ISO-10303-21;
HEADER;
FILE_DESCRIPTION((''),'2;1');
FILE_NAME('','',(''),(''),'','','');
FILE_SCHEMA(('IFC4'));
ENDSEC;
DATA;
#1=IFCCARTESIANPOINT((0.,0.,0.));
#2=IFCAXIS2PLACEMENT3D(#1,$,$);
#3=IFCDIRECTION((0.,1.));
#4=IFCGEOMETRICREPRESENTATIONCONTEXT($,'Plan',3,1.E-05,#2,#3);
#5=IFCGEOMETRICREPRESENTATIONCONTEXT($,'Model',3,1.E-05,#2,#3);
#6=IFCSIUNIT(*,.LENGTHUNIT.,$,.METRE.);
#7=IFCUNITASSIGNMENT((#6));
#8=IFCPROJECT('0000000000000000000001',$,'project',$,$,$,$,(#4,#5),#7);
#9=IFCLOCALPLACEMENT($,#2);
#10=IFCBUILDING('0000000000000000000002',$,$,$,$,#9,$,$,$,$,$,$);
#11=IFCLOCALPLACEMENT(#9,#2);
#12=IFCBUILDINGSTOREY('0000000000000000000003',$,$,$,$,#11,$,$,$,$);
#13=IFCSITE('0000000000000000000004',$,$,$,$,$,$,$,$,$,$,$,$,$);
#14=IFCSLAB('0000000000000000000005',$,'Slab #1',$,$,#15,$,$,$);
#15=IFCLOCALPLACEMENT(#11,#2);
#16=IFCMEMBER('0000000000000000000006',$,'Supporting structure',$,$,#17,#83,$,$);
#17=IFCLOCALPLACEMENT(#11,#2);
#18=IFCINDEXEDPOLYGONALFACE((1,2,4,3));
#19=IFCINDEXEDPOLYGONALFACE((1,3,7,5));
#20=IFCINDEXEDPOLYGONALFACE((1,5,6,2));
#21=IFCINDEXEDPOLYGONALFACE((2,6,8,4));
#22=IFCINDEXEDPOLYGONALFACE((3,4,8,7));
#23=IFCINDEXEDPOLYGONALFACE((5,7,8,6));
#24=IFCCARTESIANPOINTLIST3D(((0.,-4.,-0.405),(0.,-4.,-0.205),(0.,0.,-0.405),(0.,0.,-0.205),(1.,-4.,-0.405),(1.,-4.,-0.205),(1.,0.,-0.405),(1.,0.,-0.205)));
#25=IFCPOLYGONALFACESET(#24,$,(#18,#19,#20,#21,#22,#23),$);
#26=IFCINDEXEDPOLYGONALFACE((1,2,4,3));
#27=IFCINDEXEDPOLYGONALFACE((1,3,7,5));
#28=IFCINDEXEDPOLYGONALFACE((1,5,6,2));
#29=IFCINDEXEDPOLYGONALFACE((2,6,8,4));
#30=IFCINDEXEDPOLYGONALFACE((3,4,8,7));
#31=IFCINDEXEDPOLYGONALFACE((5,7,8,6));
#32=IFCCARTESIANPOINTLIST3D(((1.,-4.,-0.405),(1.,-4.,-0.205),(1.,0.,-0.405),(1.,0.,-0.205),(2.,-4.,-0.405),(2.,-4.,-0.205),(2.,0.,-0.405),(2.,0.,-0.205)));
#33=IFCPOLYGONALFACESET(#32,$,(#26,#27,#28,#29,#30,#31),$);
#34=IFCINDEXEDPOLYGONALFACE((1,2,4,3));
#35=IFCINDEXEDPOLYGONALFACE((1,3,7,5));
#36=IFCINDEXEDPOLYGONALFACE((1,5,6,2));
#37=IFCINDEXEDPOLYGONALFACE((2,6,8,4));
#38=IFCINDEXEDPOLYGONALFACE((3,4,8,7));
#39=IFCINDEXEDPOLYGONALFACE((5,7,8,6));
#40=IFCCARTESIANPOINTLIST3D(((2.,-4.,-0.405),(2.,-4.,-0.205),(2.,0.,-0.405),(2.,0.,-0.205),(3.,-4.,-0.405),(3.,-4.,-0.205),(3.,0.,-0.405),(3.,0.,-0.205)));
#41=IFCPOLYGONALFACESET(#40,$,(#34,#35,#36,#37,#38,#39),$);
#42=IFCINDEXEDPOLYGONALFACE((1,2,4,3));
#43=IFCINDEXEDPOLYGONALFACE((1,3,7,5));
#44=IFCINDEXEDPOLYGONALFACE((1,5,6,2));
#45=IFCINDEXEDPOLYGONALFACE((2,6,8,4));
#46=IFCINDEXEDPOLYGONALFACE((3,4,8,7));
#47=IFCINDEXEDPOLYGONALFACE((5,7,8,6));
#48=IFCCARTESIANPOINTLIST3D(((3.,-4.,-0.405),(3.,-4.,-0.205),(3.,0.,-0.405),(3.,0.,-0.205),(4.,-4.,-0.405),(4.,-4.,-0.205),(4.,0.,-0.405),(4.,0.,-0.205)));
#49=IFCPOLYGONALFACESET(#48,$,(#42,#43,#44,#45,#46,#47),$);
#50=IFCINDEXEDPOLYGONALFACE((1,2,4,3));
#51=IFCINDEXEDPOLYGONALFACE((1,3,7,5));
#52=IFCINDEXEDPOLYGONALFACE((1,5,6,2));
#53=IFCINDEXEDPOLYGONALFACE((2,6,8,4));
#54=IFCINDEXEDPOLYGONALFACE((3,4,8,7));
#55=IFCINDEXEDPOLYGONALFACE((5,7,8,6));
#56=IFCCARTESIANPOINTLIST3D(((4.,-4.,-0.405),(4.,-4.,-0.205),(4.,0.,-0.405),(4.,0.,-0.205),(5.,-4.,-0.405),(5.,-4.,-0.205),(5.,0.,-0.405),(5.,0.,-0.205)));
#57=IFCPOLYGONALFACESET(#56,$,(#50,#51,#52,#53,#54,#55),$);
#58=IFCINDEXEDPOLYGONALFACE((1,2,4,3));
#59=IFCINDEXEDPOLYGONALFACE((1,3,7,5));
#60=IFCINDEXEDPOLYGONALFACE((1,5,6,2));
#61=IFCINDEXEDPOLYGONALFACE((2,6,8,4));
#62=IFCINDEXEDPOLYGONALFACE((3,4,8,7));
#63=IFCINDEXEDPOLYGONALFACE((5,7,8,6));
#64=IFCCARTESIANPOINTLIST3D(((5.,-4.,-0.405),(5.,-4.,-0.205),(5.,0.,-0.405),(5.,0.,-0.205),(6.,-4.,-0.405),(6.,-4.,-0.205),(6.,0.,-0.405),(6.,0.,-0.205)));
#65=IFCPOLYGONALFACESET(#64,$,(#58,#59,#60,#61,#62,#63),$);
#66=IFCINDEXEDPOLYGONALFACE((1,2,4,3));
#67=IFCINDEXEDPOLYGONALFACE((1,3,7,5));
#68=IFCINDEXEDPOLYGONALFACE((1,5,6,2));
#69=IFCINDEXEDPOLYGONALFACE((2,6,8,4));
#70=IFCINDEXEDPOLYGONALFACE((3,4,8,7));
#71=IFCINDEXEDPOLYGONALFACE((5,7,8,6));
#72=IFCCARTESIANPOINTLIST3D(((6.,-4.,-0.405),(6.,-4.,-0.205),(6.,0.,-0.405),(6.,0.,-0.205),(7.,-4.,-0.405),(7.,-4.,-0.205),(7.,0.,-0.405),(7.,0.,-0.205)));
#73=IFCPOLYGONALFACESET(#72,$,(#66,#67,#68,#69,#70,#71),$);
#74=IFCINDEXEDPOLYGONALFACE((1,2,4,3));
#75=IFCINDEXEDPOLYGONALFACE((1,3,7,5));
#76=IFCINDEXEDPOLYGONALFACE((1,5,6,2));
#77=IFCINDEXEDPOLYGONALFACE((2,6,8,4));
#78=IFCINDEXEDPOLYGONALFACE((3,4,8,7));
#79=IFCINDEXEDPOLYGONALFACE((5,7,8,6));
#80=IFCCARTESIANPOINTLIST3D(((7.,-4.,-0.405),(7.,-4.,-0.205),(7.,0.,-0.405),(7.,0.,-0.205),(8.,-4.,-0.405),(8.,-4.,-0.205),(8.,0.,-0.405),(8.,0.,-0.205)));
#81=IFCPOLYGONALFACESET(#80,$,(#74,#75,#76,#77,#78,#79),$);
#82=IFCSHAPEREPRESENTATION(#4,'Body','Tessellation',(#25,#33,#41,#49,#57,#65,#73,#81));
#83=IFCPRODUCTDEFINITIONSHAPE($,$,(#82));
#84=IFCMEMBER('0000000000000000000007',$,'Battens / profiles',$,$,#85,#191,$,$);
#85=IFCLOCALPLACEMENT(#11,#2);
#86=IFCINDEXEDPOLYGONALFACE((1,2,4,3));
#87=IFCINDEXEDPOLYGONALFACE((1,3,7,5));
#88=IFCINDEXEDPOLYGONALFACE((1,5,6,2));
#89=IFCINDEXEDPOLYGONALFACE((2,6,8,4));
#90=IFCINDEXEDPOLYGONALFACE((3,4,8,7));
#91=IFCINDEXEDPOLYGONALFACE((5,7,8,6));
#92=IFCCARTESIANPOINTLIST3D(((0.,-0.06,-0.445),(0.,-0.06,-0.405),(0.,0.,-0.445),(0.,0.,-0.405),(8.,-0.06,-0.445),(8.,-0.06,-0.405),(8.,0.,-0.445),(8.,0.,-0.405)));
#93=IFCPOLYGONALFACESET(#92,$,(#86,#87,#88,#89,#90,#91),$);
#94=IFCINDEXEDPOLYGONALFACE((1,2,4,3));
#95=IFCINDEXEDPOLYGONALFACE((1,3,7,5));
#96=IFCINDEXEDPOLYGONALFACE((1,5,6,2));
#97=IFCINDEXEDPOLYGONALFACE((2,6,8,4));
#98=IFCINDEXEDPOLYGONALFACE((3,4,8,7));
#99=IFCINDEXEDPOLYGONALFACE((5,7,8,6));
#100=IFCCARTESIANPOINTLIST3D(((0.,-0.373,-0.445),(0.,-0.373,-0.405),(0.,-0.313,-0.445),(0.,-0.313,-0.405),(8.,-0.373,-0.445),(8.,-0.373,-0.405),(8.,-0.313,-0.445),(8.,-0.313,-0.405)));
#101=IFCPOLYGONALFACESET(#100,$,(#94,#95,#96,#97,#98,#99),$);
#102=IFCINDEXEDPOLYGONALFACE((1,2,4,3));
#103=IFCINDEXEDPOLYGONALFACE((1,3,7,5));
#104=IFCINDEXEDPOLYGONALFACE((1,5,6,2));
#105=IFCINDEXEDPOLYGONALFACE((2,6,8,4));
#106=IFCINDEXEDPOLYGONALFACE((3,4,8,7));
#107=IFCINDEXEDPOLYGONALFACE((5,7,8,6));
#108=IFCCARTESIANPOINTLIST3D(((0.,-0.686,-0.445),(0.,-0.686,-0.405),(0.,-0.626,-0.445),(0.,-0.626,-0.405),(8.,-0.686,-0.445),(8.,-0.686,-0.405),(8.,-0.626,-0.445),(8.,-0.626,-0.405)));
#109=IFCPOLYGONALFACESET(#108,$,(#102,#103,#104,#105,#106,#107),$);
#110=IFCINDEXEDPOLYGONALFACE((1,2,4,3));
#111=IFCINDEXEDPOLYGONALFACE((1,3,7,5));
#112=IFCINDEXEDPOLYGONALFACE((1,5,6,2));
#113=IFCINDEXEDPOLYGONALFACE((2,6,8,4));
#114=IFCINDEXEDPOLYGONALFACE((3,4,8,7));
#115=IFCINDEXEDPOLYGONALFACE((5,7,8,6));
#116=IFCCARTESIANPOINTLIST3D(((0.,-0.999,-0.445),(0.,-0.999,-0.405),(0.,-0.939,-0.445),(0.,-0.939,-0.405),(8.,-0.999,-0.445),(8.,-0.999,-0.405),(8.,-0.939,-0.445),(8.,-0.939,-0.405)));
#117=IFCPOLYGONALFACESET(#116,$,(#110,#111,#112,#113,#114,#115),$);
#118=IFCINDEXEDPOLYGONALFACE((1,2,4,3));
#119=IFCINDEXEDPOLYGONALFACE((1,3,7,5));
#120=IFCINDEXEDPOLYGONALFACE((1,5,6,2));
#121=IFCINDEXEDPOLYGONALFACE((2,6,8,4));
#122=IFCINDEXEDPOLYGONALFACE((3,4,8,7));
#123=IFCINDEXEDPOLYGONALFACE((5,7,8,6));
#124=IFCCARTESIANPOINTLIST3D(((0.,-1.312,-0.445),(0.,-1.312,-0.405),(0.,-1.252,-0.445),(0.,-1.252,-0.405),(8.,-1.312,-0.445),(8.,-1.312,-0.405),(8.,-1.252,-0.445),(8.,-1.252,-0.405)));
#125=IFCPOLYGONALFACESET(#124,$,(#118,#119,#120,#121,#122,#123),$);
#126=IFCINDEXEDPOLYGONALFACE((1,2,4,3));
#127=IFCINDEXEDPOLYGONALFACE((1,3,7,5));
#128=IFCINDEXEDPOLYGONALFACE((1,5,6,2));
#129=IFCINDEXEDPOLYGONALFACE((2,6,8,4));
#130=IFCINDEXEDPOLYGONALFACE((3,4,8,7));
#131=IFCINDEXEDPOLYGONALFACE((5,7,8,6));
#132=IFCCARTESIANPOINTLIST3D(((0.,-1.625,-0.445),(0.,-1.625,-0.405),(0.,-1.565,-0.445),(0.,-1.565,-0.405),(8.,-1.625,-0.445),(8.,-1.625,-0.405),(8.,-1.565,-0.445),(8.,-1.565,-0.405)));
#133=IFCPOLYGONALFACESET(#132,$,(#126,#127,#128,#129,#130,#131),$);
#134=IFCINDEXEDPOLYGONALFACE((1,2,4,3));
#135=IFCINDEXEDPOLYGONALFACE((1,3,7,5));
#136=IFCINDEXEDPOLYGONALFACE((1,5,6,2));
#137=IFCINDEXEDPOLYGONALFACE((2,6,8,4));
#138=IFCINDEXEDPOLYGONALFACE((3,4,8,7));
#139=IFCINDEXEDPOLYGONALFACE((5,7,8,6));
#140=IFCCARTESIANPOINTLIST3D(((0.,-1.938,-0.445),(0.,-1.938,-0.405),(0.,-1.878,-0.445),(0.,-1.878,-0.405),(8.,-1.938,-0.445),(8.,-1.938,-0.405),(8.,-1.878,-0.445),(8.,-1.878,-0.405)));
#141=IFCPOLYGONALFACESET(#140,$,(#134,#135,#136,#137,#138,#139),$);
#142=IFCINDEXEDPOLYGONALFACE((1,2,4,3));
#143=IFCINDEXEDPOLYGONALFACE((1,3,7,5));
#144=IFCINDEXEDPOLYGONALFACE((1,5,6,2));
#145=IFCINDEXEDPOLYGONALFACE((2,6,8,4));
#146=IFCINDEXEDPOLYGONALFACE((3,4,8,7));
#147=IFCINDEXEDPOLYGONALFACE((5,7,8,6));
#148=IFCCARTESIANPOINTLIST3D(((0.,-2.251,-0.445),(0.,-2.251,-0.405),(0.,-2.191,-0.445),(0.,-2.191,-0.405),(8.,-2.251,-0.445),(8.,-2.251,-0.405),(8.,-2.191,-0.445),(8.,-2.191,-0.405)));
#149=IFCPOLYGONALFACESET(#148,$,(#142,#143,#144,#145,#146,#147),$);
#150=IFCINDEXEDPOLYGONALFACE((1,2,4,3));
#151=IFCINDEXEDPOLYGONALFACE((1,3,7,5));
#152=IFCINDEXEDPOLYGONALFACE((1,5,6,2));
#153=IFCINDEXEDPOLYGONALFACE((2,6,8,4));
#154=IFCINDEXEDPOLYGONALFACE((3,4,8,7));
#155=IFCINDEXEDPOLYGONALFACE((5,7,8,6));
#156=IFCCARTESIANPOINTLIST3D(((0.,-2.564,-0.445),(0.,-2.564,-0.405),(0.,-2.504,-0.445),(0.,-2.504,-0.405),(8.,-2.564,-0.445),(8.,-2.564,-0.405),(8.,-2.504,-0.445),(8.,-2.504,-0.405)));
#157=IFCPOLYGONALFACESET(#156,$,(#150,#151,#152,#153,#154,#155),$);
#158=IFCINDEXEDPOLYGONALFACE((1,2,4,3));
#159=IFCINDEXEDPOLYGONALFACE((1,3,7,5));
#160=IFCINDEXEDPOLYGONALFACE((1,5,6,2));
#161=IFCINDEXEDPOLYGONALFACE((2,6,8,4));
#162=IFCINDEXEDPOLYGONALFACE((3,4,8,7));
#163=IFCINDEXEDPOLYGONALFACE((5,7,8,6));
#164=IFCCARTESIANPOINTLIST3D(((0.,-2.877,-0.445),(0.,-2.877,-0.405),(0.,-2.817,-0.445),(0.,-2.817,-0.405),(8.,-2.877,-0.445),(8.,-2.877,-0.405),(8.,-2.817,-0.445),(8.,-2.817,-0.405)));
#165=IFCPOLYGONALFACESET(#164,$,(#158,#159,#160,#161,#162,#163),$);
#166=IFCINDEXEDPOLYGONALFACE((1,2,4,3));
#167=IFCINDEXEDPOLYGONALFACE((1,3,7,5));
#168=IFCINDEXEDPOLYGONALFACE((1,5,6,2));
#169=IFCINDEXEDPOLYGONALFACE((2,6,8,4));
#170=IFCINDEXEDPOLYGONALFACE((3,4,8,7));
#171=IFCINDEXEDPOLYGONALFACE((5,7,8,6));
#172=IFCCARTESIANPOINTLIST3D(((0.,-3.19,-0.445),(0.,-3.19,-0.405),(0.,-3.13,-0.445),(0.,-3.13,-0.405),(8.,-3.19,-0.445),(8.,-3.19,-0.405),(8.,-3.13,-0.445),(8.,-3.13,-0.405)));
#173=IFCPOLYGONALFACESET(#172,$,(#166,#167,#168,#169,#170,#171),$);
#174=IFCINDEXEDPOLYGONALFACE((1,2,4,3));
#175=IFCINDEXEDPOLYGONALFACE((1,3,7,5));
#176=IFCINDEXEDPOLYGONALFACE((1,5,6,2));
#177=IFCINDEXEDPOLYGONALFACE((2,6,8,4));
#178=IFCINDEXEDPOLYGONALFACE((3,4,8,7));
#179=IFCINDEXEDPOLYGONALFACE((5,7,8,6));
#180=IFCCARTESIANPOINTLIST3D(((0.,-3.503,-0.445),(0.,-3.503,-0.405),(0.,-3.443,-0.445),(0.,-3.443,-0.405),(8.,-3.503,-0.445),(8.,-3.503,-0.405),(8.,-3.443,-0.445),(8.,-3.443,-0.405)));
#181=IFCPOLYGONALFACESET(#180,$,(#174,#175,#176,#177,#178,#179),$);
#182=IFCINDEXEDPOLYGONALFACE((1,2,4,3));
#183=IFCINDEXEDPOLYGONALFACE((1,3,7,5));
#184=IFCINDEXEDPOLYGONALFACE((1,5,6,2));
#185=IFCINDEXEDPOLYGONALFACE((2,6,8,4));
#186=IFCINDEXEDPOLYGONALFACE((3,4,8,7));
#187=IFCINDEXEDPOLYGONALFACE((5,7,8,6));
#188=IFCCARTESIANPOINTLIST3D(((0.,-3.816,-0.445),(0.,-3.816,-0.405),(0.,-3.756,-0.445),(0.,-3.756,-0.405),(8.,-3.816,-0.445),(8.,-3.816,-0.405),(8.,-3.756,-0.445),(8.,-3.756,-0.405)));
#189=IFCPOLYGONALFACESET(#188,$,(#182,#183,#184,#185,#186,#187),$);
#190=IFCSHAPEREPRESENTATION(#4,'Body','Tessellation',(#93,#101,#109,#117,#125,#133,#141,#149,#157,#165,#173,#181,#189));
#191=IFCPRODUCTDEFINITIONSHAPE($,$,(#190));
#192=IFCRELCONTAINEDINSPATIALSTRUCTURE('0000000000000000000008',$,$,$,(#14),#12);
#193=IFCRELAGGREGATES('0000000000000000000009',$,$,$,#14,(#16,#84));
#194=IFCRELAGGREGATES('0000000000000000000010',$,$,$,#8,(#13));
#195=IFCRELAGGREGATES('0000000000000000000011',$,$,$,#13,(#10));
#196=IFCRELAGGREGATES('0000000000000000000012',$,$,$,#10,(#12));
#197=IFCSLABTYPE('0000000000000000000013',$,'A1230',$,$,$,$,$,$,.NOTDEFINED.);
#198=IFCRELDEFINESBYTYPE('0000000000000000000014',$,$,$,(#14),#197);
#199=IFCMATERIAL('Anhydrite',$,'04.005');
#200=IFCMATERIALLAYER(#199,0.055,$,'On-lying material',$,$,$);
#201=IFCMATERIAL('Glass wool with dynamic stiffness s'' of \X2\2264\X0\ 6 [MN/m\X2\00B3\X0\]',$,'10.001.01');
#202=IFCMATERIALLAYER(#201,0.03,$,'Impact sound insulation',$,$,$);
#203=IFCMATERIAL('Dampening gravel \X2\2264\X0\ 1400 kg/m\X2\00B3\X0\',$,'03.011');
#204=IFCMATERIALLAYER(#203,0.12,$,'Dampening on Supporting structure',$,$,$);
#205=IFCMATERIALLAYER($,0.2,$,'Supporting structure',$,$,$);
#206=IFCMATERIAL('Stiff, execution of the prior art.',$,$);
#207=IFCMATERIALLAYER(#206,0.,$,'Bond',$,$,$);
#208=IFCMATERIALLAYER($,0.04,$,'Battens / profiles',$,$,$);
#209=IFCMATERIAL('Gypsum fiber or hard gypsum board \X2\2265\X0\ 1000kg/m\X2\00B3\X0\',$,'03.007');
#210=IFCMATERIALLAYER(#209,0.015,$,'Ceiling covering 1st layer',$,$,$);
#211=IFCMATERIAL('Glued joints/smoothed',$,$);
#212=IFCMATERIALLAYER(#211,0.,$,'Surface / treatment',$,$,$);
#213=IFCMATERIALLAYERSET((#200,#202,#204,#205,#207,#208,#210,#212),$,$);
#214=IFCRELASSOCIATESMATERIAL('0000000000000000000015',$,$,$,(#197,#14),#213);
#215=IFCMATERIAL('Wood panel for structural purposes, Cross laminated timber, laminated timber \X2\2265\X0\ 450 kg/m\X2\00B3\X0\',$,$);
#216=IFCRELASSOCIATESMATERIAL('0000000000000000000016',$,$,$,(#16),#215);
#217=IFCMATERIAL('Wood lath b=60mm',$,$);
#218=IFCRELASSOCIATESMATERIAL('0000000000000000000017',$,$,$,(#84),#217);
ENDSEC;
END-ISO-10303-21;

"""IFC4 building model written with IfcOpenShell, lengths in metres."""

from ifc_helpers import new_model, si_unit, direction, frame, frame_2d, origin, place, context, project, spatial, rectangle, extrude, material, layer, layer_set, type_object, element, aggregate, save


model = new_model("IFC4")

# Units and contexts
plan_context = context("Plan", 3, precision=1e-05, world=origin(), true_north=direction((0.0, 1.0)))
model_context = context("Model", 3, precision=1e-05, world=origin(), true_north=direction((0.0, 1.0)))
ifc_project = project(units=[si_unit("LENGTHUNIT", "METRE")], contexts=[plan_context, model_context])

# Site, building, storey
site = spatial("IfcSite", under=ifc_project)
building_placement = place(None, origin())
building = spatial("IfcBuilding", under=site, at=building_placement)
storey_placement = place(building_placement, origin())
storey = spatial("IfcBuildingStorey", under=building, at=storey_placement)

# Slab, members
ifc_material_1 = material(Name="Anhydrite", Category="04.005")
ifc_layer_1 = layer(ifc_material_1, 0.055, Name="On-lying material")
ifc_material_2 = material(Name="Glass wool with dynamic stiffness s' of ≤ 6 [MN/m³]", Category="10.001.01")
ifc_layer_2 = layer(ifc_material_2, 0.03, Name="Impact sound insulation")
ifc_material_3 = material(Name="Dampening gravel ≤ 1400 kg/m³", Category="03.011")
ifc_layer_3 = layer(ifc_material_3, 0.12, Name="Dampening on Supporting structure")
ifc_layer_4 = layer(None, 0.2, Name="Supporting structure")
ifc_material_4 = material(Name="Stiff, execution of the prior art.")
ifc_layer_5 = layer(ifc_material_4, 0.0, Name="Bond")
ifc_layer_6 = layer(None, 0.04, Name="Battens / profiles")
ifc_material_5 = material(Name="Gypsum fiber or hard gypsum board ≥ 1000kg/m³", Category="03.007")
ifc_layer_7 = layer(ifc_material_5, 0.015, Name="Ceiling covering 1st layer")
ifc_material_6 = material(Name="Glued joints/smoothed")
ifc_layer_8 = layer(ifc_material_6, 0.0, Name="Surface / treatment")
ifc_layer_set = layer_set([ifc_layer_1, ifc_layer_2, ifc_layer_3, ifc_layer_4, ifc_layer_5, ifc_layer_6, ifc_layer_7, ifc_layer_8])
slab_type = type_object("IfcSlabType", Name="A1230", PredefinedType="NOTDEFINED", material=ifc_layer_set)
slab_placement = place(None, frame((0.0, 0.0, 0.0), z_axis=(0.0, 0.0, -1.0), x_axis=(1.0, 0.0, 0.0)))
slab = element("IfcSlab", 1, at=slab_placement, inside=storey, type_object=slab_type, material=ifc_layer_set, Name="Slab #1")
ifc_material_7 = material(Name="Wood panel for structural purposes, Cross laminated timber, laminated timber ≥ 450 kg/m³")
member_1_placement = place(slab_placement, origin())
member_1 = element("IfcMember", 2, at=member_1_placement, material=ifc_material_7, Name="Supporting structure", context=plan_context, shape_type="SweptSolid", body=[
    extrude(rectangle(XDim=1.0, YDim=0.2, at=frame_2d((0.5, 0.1), x_axis=(1.0, 0.0))), frame((0.0, 4.0, 0.205), z_axis=(0.0, -1.0, 0.0), x_axis=(1.0, 0.0, 0.0)), (0.0, 0.0, 1.0), 4.0),
    extrude(rectangle(XDim=1.0, YDim=0.2, at=frame_2d((0.5, 0.1), x_axis=(1.0, 0.0))), frame((1.0, 4.0, 0.205), z_axis=(0.0, -1.0, 0.0), x_axis=(1.0, 0.0, 0.0)), (0.0, 0.0, 1.0), 4.0),
    extrude(rectangle(XDim=1.0, YDim=0.2, at=frame_2d((0.5, 0.1), x_axis=(1.0, 0.0))), frame((2.0, 4.0, 0.205), z_axis=(0.0, -1.0, 0.0), x_axis=(1.0, 0.0, 0.0)), (0.0, 0.0, 1.0), 4.0),
    extrude(rectangle(XDim=1.0, YDim=0.2, at=frame_2d((0.5, 0.1), x_axis=(1.0, 0.0))), frame((3.0, 4.0, 0.205), z_axis=(0.0, -1.0, 0.0), x_axis=(1.0, 0.0, 0.0)), (0.0, 0.0, 1.0), 4.0),
    extrude(rectangle(XDim=1.0, YDim=0.2, at=frame_2d((0.5, 0.1), x_axis=(1.0, 0.0))), frame((4.0, 4.0, 0.205), z_axis=(0.0, -1.0, 0.0), x_axis=(1.0, 0.0, 0.0)), (0.0, 0.0, 1.0), 4.0),
    extrude(rectangle(XDim=1.0, YDim=0.2, at=frame_2d((0.5, 0.1), x_axis=(1.0, 0.0))), frame((5.0, 4.0, 0.205), z_axis=(0.0, -1.0, 0.0), x_axis=(1.0, 0.0, 0.0)), (0.0, 0.0, 1.0), 4.0),
    extrude(rectangle(XDim=1.0, YDim=0.2, at=frame_2d((0.5, 0.1), x_axis=(1.0, 0.0))), frame((6.0, 4.0, 0.205), z_axis=(0.0, -1.0, 0.0), x_axis=(1.0, 0.0, 0.0)), (0.0, 0.0, 1.0), 4.0),
    extrude(rectangle(XDim=1.0, YDim=0.2, at=frame_2d((0.5, 0.1), x_axis=(1.0, 0.0))), frame((7.0, 4.0, 0.205), z_axis=(0.0, -1.0, 0.0), x_axis=(1.0, 0.0, 0.0)), (0.0, 0.0, 1.0), 4.0),
])
ifc_material_8 = material(Name="Wood lath b=60mm")
member_2_placement = place(slab_placement, origin())
member_2 = element("IfcMember", 3, at=member_2_placement, material=ifc_material_8, Name="Battens / profiles", context=plan_context, shape_type="SweptSolid", body=[
    extrude(rectangle(XDim=0.06, YDim=0.04, at=frame_2d((0.03, 0.02), x_axis=(1.0, 0.0))), frame((0.0, 0.0, 0.405), z_axis=(1.0, 0.0, 0.0), x_axis=(0.0, 1.0, 0.0)), (0.0, 0.0, 1.0), 8.0),
    extrude(rectangle(XDim=0.06, YDim=0.04, at=frame_2d((0.03, 0.02), x_axis=(1.0, 0.0))), frame((0.0, 0.313, 0.405), z_axis=(1.0, 0.0, 0.0), x_axis=(0.0, 1.0, 0.0)), (0.0, 0.0, 1.0), 8.0),
    extrude(rectangle(XDim=0.06, YDim=0.04, at=frame_2d((0.03, 0.02), x_axis=(1.0, 0.0))), frame((0.0, 0.626, 0.405), z_axis=(1.0, 0.0, 0.0), x_axis=(0.0, 1.0, 0.0)), (0.0, 0.0, 1.0), 8.0),
    extrude(rectangle(XDim=0.06, YDim=0.04, at=frame_2d((0.03, 0.02), x_axis=(1.0, 0.0))), frame((0.0, 0.939, 0.405), z_axis=(1.0, 0.0, 0.0), x_axis=(0.0, 1.0, 0.0)), (0.0, 0.0, 1.0), 8.0),
    extrude(rectangle(XDim=0.06, YDim=0.04, at=frame_2d((0.03, 0.02), x_axis=(1.0, 0.0))), frame((0.0, 1.252, 0.405), z_axis=(1.0, 0.0, 0.0), x_axis=(0.0, 1.0, 0.0)), (0.0, 0.0, 1.0), 8.0),
    extrude(rectangle(XDim=0.06, YDim=0.04, at=frame_2d((0.03, 0.02), x_axis=(1.0, 0.0))), frame((0.0, 1.565, 0.405), z_axis=(1.0, 0.0, 0.0), x_axis=(0.0, 1.0, 0.0)), (0.0, 0.0, 1.0), 8.0),
    extrude(rectangle(XDim=0.06, YDim=0.04, at=frame_2d((0.03, 0.02), x_axis=(1.0, 0.0))), frame((0.0, 1.878, 0.405), z_axis=(1.0, 0.0, 0.0), x_axis=(0.0, 1.0, 0.0)), (0.0, 0.0, 1.0), 8.0),
    extrude(rectangle(XDim=0.06, YDim=0.04, at=frame_2d((0.03, 0.02), x_axis=(1.0, 0.0))), frame((0.0, 2.191, 0.405), z_axis=(1.0, 0.0, 0.0), x_axis=(0.0, 1.0, 0.0)), (0.0, 0.0, 1.0), 8.0),
    extrude(rectangle(XDim=0.06, YDim=0.04, at=frame_2d((0.03, 0.02), x_axis=(1.0, 0.0))), frame((0.0, 2.504, 0.405), z_axis=(1.0, 0.0, 0.0), x_axis=(0.0, 1.0, 0.0)), (0.0, 0.0, 1.0), 8.0),
    extrude(rectangle(XDim=0.06, YDim=0.04, at=frame_2d((0.03, 0.02), x_axis=(1.0, 0.0))), frame((0.0, 2.817, 0.405), z_axis=(1.0, 0.0, 0.0), x_axis=(0.0, 1.0, 0.0)), (0.0, 0.0, 1.0), 8.0),
    extrude(rectangle(XDim=0.06, YDim=0.04, at=frame_2d((0.03, 0.02), x_axis=(1.0, 0.0))), frame((0.0, 3.13, 0.405), z_axis=(1.0, 0.0, 0.0), x_axis=(0.0, 1.0, 0.0)), (0.0, 0.0, 1.0), 8.0),
    extrude(rectangle(XDim=0.06, YDim=0.04, at=frame_2d((0.03, 0.02), x_axis=(1.0, 0.0))), frame((0.0, 3.443, 0.405), z_axis=(1.0, 0.0, 0.0), x_axis=(0.0, 1.0, 0.0)), (0.0, 0.0, 1.0), 8.0),
    extrude(rectangle(XDim=0.06, YDim=0.04, at=frame_2d((0.03, 0.02), x_axis=(1.0, 0.0))), frame((0.0, 3.756, 0.405), z_axis=(1.0, 0.0, 0.0), x_axis=(0.0, 1.0, 0.0)), (0.0, 0.0, 1.0), 8.0),
])
aggregate(slab, [member_1, member_2])

save(model, "model.ifc")
